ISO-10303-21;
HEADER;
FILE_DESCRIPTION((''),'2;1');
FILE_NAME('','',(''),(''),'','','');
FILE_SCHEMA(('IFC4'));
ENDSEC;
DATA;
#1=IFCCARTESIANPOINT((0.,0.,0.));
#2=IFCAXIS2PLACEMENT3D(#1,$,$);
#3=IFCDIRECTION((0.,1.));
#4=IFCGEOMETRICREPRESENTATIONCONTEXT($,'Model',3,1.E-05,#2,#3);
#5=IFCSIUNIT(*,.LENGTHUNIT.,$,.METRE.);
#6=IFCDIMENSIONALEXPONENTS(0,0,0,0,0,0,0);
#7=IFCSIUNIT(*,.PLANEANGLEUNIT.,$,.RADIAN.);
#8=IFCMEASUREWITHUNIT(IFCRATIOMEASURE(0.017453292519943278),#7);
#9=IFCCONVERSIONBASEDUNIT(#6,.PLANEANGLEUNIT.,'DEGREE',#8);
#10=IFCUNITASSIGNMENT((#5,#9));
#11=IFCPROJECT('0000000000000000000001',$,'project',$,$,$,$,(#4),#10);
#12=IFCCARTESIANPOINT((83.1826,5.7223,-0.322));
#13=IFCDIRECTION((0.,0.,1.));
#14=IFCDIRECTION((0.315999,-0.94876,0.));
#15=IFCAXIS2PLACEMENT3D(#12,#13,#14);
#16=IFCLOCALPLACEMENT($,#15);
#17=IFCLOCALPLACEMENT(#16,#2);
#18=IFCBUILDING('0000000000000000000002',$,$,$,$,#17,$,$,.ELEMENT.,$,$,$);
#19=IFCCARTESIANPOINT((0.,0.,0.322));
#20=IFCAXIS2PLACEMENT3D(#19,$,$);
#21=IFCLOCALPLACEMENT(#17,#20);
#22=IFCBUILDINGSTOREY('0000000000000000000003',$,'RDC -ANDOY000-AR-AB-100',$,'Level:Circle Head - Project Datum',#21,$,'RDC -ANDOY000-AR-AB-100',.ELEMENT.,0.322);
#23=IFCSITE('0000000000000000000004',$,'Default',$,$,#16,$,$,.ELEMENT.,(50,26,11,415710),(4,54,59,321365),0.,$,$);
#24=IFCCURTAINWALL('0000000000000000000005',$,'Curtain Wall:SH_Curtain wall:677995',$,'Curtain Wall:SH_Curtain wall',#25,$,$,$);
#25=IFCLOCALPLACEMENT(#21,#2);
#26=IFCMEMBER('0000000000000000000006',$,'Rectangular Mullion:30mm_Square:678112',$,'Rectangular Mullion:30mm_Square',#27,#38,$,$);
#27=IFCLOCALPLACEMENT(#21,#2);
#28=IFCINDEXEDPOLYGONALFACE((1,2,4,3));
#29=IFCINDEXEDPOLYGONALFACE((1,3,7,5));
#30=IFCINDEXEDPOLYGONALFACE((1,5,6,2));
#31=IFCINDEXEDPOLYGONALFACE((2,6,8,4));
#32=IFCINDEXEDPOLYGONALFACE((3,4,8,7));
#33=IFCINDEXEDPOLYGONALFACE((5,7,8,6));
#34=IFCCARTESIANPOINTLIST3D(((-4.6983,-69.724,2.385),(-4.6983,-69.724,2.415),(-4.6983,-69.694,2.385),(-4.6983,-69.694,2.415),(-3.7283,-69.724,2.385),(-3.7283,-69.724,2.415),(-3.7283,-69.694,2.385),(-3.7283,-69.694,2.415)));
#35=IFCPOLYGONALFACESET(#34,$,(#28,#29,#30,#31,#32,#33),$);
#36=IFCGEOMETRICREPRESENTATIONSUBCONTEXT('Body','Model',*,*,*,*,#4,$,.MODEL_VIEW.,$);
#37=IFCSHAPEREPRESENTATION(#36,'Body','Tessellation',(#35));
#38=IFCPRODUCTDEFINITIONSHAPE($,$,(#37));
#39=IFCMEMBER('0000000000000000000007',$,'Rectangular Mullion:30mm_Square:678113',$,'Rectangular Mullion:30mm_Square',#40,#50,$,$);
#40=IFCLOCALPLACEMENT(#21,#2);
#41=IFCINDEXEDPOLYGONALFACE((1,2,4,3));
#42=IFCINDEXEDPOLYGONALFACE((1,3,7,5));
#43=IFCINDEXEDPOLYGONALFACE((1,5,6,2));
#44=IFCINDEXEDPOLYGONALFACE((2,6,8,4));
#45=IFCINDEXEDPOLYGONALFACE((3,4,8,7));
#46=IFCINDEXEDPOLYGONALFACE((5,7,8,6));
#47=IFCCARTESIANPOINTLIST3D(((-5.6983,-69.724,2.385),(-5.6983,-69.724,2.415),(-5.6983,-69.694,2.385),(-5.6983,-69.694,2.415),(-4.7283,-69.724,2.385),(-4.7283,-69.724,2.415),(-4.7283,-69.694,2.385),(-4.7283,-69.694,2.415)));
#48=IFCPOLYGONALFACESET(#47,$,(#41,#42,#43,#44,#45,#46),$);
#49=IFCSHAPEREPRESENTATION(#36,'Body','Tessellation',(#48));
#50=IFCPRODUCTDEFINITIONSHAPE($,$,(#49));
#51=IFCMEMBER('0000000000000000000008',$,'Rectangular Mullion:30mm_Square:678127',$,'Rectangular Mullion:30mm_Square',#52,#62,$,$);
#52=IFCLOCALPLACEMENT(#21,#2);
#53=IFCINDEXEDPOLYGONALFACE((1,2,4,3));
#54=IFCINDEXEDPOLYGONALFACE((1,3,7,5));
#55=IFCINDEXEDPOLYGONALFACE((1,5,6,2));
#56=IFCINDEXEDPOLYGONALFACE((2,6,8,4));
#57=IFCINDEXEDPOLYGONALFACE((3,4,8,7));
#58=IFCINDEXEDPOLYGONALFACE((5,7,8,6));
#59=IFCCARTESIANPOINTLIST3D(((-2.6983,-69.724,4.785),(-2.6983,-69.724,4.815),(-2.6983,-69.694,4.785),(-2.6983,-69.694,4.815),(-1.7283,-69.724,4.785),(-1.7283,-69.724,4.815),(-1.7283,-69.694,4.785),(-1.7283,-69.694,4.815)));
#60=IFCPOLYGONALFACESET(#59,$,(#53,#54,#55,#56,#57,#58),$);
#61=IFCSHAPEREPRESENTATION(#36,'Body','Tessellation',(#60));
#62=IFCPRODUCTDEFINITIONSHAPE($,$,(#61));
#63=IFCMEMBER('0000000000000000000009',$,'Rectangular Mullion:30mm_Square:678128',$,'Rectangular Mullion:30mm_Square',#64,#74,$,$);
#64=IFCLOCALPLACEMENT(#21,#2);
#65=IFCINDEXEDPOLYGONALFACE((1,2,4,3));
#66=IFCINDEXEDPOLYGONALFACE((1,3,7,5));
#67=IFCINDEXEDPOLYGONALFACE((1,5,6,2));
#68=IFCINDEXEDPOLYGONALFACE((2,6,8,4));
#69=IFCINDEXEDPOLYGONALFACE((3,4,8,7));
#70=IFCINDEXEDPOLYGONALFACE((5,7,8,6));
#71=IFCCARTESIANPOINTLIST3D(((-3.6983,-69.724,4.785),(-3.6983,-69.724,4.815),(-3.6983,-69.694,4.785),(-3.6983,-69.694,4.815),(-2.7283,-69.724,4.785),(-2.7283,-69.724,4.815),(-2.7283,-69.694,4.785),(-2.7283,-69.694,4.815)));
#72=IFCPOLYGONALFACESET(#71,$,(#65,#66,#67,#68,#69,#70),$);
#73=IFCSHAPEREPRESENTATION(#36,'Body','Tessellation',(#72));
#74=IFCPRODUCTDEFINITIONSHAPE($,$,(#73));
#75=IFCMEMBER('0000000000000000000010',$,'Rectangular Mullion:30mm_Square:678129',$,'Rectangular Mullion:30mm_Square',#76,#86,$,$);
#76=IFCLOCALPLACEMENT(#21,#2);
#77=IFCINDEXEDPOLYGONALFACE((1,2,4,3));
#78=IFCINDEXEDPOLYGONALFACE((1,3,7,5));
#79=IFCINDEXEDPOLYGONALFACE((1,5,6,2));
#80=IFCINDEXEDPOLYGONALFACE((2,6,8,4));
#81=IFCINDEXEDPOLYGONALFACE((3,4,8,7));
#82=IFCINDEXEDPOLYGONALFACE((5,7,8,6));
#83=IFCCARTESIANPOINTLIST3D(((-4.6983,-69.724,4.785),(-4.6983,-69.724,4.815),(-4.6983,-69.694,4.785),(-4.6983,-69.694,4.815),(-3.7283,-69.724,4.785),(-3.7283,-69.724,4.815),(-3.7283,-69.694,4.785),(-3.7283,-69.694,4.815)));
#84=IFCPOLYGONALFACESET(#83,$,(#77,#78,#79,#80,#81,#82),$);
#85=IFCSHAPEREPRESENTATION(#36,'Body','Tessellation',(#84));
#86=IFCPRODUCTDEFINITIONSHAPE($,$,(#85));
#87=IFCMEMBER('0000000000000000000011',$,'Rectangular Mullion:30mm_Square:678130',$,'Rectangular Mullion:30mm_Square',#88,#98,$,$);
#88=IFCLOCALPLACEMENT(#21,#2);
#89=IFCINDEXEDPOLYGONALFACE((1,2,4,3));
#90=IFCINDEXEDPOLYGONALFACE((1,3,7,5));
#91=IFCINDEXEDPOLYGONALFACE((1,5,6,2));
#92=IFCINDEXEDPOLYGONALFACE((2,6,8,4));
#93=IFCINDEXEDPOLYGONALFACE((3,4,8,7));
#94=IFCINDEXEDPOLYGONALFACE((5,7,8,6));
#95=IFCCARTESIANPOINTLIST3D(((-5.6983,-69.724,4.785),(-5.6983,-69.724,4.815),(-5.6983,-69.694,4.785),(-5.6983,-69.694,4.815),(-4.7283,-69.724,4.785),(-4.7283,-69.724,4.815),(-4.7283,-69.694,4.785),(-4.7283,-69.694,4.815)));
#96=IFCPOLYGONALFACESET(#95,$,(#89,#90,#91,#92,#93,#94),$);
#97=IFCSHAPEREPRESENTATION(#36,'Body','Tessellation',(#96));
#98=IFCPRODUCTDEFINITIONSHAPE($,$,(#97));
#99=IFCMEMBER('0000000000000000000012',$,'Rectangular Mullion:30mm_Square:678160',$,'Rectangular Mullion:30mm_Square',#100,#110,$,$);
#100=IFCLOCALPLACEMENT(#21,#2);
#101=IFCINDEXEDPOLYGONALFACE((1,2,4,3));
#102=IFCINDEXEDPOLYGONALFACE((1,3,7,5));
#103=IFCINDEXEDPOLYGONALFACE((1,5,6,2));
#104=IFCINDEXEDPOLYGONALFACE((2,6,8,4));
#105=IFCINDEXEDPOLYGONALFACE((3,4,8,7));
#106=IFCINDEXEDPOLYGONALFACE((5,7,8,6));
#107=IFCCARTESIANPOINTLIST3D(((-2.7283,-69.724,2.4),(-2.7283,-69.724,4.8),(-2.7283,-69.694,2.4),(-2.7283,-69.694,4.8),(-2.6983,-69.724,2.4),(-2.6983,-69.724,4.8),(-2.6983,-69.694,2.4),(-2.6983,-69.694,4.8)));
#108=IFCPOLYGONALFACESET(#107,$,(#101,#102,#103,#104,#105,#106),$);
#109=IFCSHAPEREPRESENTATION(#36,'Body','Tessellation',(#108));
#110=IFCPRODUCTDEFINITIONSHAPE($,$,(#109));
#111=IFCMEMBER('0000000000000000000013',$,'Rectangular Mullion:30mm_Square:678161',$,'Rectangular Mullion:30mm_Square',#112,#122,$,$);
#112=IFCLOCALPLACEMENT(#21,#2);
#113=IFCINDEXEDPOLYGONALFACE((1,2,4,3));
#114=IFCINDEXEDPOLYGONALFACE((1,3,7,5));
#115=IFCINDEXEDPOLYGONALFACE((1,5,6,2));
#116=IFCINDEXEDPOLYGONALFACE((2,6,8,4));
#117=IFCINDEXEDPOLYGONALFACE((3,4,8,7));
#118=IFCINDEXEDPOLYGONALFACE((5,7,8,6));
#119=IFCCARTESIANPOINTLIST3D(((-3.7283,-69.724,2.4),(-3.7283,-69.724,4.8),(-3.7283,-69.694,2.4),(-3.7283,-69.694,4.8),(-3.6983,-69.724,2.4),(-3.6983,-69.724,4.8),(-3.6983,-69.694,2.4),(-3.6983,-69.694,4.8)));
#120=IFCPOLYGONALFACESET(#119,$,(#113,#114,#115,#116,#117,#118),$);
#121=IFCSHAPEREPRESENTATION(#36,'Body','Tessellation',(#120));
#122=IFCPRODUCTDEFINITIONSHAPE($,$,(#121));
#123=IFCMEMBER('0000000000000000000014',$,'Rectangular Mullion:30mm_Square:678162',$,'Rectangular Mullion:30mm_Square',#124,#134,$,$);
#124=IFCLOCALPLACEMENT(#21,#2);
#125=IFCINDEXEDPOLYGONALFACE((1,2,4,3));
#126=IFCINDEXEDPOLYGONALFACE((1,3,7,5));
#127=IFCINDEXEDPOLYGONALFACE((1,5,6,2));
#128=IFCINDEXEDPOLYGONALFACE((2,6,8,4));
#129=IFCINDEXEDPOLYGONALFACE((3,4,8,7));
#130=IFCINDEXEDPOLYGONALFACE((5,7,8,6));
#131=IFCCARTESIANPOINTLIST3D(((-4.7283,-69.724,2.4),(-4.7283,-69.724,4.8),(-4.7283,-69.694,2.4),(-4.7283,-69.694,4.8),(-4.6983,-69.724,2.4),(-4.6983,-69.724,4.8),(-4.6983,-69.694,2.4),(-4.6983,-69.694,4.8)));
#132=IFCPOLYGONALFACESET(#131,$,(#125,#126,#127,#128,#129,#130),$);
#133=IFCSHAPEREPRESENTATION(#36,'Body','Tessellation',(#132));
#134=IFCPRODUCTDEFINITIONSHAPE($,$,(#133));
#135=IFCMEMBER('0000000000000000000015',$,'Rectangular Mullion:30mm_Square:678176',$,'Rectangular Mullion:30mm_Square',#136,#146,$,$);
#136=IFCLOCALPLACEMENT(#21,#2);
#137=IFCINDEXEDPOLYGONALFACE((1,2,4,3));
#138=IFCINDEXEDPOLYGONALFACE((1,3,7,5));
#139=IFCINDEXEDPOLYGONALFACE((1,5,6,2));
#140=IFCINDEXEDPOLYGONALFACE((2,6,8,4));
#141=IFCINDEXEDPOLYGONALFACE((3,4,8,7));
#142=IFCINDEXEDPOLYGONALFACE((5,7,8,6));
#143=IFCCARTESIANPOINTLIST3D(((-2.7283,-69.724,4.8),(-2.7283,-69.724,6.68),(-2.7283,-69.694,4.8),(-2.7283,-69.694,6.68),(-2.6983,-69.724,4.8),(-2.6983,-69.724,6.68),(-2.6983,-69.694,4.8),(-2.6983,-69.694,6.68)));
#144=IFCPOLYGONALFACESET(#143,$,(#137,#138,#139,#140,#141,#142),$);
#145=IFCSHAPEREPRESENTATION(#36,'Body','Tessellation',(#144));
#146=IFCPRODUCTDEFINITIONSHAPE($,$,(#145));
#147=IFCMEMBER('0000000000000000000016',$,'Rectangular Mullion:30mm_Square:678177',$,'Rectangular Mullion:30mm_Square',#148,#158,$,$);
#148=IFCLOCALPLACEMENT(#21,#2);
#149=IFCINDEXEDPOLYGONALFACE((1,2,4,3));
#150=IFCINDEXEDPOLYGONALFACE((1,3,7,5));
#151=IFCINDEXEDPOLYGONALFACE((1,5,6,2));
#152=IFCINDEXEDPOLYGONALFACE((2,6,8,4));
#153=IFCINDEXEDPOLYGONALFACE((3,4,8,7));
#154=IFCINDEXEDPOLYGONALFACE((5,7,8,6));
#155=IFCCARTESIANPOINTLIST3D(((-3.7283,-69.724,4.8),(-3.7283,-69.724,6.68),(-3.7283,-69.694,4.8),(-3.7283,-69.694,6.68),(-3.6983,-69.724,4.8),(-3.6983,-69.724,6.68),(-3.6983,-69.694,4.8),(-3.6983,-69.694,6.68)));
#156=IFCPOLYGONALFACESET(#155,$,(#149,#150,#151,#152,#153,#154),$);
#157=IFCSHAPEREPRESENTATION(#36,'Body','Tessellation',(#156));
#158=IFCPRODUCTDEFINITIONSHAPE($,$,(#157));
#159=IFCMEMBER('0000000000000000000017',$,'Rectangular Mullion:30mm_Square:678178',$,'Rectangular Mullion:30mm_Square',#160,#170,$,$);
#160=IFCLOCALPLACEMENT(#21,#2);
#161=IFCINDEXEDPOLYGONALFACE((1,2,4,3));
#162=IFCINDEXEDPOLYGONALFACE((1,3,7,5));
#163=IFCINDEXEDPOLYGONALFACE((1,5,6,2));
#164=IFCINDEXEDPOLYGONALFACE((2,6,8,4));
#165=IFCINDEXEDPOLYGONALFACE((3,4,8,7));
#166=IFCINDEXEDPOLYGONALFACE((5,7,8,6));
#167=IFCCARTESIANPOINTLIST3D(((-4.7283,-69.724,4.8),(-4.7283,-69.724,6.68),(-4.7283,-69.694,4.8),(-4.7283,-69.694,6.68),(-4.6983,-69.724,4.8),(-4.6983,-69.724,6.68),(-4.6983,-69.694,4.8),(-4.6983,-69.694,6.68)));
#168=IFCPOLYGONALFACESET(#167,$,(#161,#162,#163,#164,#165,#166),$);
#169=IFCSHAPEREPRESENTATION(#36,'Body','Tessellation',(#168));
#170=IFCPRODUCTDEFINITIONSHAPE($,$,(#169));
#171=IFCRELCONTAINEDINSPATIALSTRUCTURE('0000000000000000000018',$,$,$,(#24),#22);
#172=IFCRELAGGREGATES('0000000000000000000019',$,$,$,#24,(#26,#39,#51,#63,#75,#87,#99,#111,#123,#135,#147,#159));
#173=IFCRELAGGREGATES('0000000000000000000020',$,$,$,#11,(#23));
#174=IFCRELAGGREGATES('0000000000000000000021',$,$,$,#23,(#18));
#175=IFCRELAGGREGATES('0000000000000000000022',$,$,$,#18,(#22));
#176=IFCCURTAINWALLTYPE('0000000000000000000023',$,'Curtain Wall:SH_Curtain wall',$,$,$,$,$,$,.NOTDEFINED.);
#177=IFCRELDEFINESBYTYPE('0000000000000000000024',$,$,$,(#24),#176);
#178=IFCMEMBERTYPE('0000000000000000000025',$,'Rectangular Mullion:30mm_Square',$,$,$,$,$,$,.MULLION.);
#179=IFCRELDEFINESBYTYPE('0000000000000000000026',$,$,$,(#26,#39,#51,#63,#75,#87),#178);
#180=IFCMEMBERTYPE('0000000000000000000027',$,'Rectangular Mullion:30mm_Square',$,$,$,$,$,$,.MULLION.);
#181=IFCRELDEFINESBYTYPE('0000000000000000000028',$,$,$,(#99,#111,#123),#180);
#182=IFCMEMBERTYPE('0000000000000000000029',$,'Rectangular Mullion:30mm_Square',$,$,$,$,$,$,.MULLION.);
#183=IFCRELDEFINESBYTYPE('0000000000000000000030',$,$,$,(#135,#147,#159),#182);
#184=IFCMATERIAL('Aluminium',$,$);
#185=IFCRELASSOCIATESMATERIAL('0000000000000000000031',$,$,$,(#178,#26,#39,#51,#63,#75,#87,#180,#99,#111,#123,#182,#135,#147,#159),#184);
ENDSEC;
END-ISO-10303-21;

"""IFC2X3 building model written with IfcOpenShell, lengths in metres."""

from ifc_helpers import new_model, entity, si_unit, converted_unit, direction, frame, origin, origin_2d_with_axis, place, context, subcontext, project, spatial, rectangle, extrude, source, transform, mapped, material, type_object, type_shapes, element, aggregate, save


model = new_model("IFC2X3")

# Units and contexts
model_context = context("Model", 3, precision=1e-05, world=origin(), true_north=direction((0.0, 1.0)))
body_context = subcontext(model_context, "Body", "Model", "MODEL_VIEW")
ifc_project = project(units=[si_unit("LENGTHUNIT", "METRE"), converted_unit("PLANEANGLEUNIT", "DEGREE", entity("IfcRatioMeasure", 0.017453292519943278), si_unit("PLANEANGLEUNIT", "RADIAN"), dimensions=[0, 0, 0, 0, 0, 0, 0])], contexts=[model_context])

# Site, building, storey
site_placement = place(None, frame((83.1826, 5.7223, -0.322), z_axis=(0.0, 0.0, 1.0), x_axis=(0.315999, -0.94876, 0.0)))
site = spatial("IfcSite", under=ifc_project, at=site_placement, Name="Default", CompositionType="ELEMENT", RefLatitude=(50, 26, 11, 415710), RefLongitude=(4, 54, 59, 321365), RefElevation=0.0)
building_placement = place(site_placement, origin())
building = spatial("IfcBuilding", under=site, at=building_placement, CompositionType="ELEMENT")
storey_placement = place(building_placement, frame((0.0, 0.0, 0.322)))
storey = spatial("IfcBuildingStorey", under=building, at=storey_placement, Name="RDC -ANDOY000-AR-AB-100", ObjectType="Level:Circle Head - Project Datum", LongName="RDC -ANDOY000-AR-AB-100", CompositionType="ELEMENT", Elevation=0.322)

# Curtain wall, members
curtain_wall_type = type_object("IfcCurtainWallType", Name="Curtain Wall:SH_Curtain wall", PredefinedType="NOTDEFINED")
curtain_wall_placement = place(storey_placement, frame((0.0, 0.0, -0.322)))
curtain_wall = element("IfcCurtainWall", 1, at=curtain_wall_placement, inside=storey, type_object=curtain_wall_type, Name="Curtain Wall:SH_Curtain wall:677995", ObjectType="Curtain Wall:SH_Curtain wall")
ifc_material_1 = material(Name="Aluminium")
member_type_1 = type_object("IfcMemberType", Name="Rectangular Mullion:30mm_Square", PredefinedType="MULLION", material=ifc_material_1)
shared_shape_1 = source(origin(), body_context, "Body", "SweptSolid", [
    extrude(rectangle(XDim=0.03, YDim=0.03, at=origin_2d_with_axis()), frame((0.0, 0.0, -0.97), z_axis=(0.0, 0.0, 1.0), x_axis=(0.0, -1.0, 0.0)), (0.0, 0.0, 1.0), 0.97),
])
type_shapes(member_type_1, [shared_shape_1])
member_1_placement = place(curtain_wall_placement, frame((-4.6983, -69.709, 2.722), z_axis=(-1.0, 0.0, 0.0), x_axis=(0.0, 0.0, 1.0)))
member_1 = element("IfcMember", 2, at=member_1_placement, type_object=member_type_1, material=ifc_material_1, Name="Rectangular Mullion:30mm_Square:678112", ObjectType="Rectangular Mullion:30mm_Square", context=body_context, shape_type="MappedRepresentation", body=[
    mapped(shared_shape_1, transform((0.0, 0.0, 0.0), scale=1.0)),
])
member_2_placement = place(curtain_wall_placement, frame((-5.6983, -69.709, 2.722), z_axis=(-1.0, 0.0, 0.0), x_axis=(0.0, 0.0, 1.0)))
member_2 = element("IfcMember", 3, at=member_2_placement, type_object=member_type_1, material=ifc_material_1, Name="Rectangular Mullion:30mm_Square:678113", ObjectType="Rectangular Mullion:30mm_Square", context=body_context, shape_type="MappedRepresentation", body=[
    mapped(shared_shape_1, transform((0.0, 0.0, 0.0), scale=1.0)),
])
member_3_placement = place(curtain_wall_placement, frame((-2.6983, -69.709, 5.122), z_axis=(-1.0, 0.0, 0.0), x_axis=(0.0, 0.0, 1.0)))
member_3 = element("IfcMember", 4, at=member_3_placement, type_object=member_type_1, material=ifc_material_1, Name="Rectangular Mullion:30mm_Square:678127", ObjectType="Rectangular Mullion:30mm_Square", context=body_context, shape_type="MappedRepresentation", body=[
    mapped(shared_shape_1, transform((0.0, 0.0, 0.0), scale=1.0)),
])
member_4_placement = place(curtain_wall_placement, frame((-3.6983, -69.709, 5.122), z_axis=(-1.0, 0.0, 0.0), x_axis=(0.0, 0.0, 1.0)))
member_4 = element("IfcMember", 5, at=member_4_placement, type_object=member_type_1, material=ifc_material_1, Name="Rectangular Mullion:30mm_Square:678128", ObjectType="Rectangular Mullion:30mm_Square", context=body_context, shape_type="MappedRepresentation", body=[
    mapped(shared_shape_1, transform((0.0, 0.0, 0.0), scale=1.0)),
])
member_5_placement = place(curtain_wall_placement, frame((-4.6983, -69.709, 5.122), z_axis=(-1.0, 0.0, 0.0), x_axis=(0.0, 0.0, 1.0)))
member_5 = element("IfcMember", 6, at=member_5_placement, type_object=member_type_1, material=ifc_material_1, Name="Rectangular Mullion:30mm_Square:678129", ObjectType="Rectangular Mullion:30mm_Square", context=body_context, shape_type="MappedRepresentation", body=[
    mapped(shared_shape_1, transform((0.0, 0.0, 0.0), scale=1.0)),
])
member_6_placement = place(curtain_wall_placement, frame((-5.6983, -69.709, 5.122), z_axis=(-1.0, 0.0, 0.0), x_axis=(0.0, 0.0, 1.0)))
member_6 = element("IfcMember", 7, at=member_6_placement, type_object=member_type_1, material=ifc_material_1, Name="Rectangular Mullion:30mm_Square:678130", ObjectType="Rectangular Mullion:30mm_Square", context=body_context, shape_type="MappedRepresentation", body=[
    mapped(shared_shape_1, transform((0.0, 0.0, 0.0), scale=1.0)),
])
member_type_2 = type_object("IfcMemberType", Name="Rectangular Mullion:30mm_Square", PredefinedType="MULLION", material=ifc_material_1)
shared_shape_2 = source(origin(), body_context, "Body", "SweptSolid", [
    extrude(rectangle(XDim=0.03, YDim=0.03, at=origin_2d_with_axis()), frame((0.0, 0.0, -2.4), z_axis=(0.0, 0.0, 1.0), x_axis=(0.0, -1.0, 0.0)), (0.0, 0.0, 1.0), 2.4),
])
type_shapes(member_type_2, [shared_shape_2])
member_7_placement = place(curtain_wall_placement, frame((-2.7133, -69.709, 2.722), z_axis=(0.0, 0.0, -1.0), x_axis=(-1.0, 0.0, 0.0)))
member_7 = element("IfcMember", 8, at=member_7_placement, type_object=member_type_2, material=ifc_material_1, Name="Rectangular Mullion:30mm_Square:678160", ObjectType="Rectangular Mullion:30mm_Square", context=body_context, shape_type="MappedRepresentation", body=[
    mapped(shared_shape_2, transform((0.0, 0.0, 0.0), scale=1.0)),
])
member_8_placement = place(curtain_wall_placement, frame((-3.7133, -69.709, 2.722), z_axis=(0.0, 0.0, -1.0), x_axis=(-1.0, 0.0, 0.0)))
member_8 = element("IfcMember", 9, at=member_8_placement, type_object=member_type_2, material=ifc_material_1, Name="Rectangular Mullion:30mm_Square:678161", ObjectType="Rectangular Mullion:30mm_Square", context=body_context, shape_type="MappedRepresentation", body=[
    mapped(shared_shape_2, transform((0.0, 0.0, 0.0), scale=1.0)),
])
member_9_placement = place(curtain_wall_placement, frame((-4.7133, -69.709, 2.722), z_axis=(0.0, 0.0, -1.0), x_axis=(-1.0, 0.0, 0.0)))
member_9 = element("IfcMember", 10, at=member_9_placement, type_object=member_type_2, material=ifc_material_1, Name="Rectangular Mullion:30mm_Square:678162", ObjectType="Rectangular Mullion:30mm_Square", context=body_context, shape_type="MappedRepresentation", body=[
    mapped(shared_shape_2, transform((0.0, 0.0, 0.0), scale=1.0)),
])
member_type_3 = type_object("IfcMemberType", Name="Rectangular Mullion:30mm_Square", PredefinedType="MULLION", material=ifc_material_1)
shared_shape_3 = source(origin(), body_context, "Body", "SweptSolid", [
    extrude(rectangle(XDim=0.03, YDim=0.03, at=origin_2d_with_axis()), frame((0.0, 0.0, -1.88), z_axis=(0.0, 0.0, 1.0), x_axis=(0.0, -1.0, 0.0)), (0.0, 0.0, 1.0), 1.88),
])
type_shapes(member_type_3, [shared_shape_3])
member_10_placement = place(curtain_wall_placement, frame((-2.7133, -69.709, 5.122), z_axis=(0.0, 0.0, -1.0), x_axis=(-1.0, 0.0, 0.0)))
member_10 = element("IfcMember", 11, at=member_10_placement, type_object=member_type_3, material=ifc_material_1, Name="Rectangular Mullion:30mm_Square:678176", ObjectType="Rectangular Mullion:30mm_Square", context=body_context, shape_type="MappedRepresentation", body=[
    mapped(shared_shape_3, transform((0.0, 0.0, 0.0), scale=1.0)),
])
member_11_placement = place(curtain_wall_placement, frame((-3.7133, -69.709, 5.122), z_axis=(0.0, 0.0, -1.0), x_axis=(-1.0, 0.0, 0.0)))
member_11 = element("IfcMember", 12, at=member_11_placement, type_object=member_type_3, material=ifc_material_1, Name="Rectangular Mullion:30mm_Square:678177", ObjectType="Rectangular Mullion:30mm_Square", context=body_context, shape_type="MappedRepresentation", body=[
    mapped(shared_shape_3, transform((0.0, 0.0, 0.0), scale=1.0)),
])
member_12_placement = place(curtain_wall_placement, frame((-4.7133, -69.709, 5.122), z_axis=(0.0, 0.0, -1.0), x_axis=(-1.0, 0.0, 0.0)))
member_12 = element("IfcMember", 13, at=member_12_placement, type_object=member_type_3, material=ifc_material_1, Name="Rectangular Mullion:30mm_Square:678178", ObjectType="Rectangular Mullion:30mm_Square", context=body_context, shape_type="MappedRepresentation", body=[
    mapped(shared_shape_3, transform((0.0, 0.0, 0.0), scale=1.0)),
])
aggregate(curtain_wall, [member_1, member_2, member_3, member_4, member_5, member_6, member_7, member_8, member_9, member_10, member_11, member_12])

save(model, "model.ifc")
